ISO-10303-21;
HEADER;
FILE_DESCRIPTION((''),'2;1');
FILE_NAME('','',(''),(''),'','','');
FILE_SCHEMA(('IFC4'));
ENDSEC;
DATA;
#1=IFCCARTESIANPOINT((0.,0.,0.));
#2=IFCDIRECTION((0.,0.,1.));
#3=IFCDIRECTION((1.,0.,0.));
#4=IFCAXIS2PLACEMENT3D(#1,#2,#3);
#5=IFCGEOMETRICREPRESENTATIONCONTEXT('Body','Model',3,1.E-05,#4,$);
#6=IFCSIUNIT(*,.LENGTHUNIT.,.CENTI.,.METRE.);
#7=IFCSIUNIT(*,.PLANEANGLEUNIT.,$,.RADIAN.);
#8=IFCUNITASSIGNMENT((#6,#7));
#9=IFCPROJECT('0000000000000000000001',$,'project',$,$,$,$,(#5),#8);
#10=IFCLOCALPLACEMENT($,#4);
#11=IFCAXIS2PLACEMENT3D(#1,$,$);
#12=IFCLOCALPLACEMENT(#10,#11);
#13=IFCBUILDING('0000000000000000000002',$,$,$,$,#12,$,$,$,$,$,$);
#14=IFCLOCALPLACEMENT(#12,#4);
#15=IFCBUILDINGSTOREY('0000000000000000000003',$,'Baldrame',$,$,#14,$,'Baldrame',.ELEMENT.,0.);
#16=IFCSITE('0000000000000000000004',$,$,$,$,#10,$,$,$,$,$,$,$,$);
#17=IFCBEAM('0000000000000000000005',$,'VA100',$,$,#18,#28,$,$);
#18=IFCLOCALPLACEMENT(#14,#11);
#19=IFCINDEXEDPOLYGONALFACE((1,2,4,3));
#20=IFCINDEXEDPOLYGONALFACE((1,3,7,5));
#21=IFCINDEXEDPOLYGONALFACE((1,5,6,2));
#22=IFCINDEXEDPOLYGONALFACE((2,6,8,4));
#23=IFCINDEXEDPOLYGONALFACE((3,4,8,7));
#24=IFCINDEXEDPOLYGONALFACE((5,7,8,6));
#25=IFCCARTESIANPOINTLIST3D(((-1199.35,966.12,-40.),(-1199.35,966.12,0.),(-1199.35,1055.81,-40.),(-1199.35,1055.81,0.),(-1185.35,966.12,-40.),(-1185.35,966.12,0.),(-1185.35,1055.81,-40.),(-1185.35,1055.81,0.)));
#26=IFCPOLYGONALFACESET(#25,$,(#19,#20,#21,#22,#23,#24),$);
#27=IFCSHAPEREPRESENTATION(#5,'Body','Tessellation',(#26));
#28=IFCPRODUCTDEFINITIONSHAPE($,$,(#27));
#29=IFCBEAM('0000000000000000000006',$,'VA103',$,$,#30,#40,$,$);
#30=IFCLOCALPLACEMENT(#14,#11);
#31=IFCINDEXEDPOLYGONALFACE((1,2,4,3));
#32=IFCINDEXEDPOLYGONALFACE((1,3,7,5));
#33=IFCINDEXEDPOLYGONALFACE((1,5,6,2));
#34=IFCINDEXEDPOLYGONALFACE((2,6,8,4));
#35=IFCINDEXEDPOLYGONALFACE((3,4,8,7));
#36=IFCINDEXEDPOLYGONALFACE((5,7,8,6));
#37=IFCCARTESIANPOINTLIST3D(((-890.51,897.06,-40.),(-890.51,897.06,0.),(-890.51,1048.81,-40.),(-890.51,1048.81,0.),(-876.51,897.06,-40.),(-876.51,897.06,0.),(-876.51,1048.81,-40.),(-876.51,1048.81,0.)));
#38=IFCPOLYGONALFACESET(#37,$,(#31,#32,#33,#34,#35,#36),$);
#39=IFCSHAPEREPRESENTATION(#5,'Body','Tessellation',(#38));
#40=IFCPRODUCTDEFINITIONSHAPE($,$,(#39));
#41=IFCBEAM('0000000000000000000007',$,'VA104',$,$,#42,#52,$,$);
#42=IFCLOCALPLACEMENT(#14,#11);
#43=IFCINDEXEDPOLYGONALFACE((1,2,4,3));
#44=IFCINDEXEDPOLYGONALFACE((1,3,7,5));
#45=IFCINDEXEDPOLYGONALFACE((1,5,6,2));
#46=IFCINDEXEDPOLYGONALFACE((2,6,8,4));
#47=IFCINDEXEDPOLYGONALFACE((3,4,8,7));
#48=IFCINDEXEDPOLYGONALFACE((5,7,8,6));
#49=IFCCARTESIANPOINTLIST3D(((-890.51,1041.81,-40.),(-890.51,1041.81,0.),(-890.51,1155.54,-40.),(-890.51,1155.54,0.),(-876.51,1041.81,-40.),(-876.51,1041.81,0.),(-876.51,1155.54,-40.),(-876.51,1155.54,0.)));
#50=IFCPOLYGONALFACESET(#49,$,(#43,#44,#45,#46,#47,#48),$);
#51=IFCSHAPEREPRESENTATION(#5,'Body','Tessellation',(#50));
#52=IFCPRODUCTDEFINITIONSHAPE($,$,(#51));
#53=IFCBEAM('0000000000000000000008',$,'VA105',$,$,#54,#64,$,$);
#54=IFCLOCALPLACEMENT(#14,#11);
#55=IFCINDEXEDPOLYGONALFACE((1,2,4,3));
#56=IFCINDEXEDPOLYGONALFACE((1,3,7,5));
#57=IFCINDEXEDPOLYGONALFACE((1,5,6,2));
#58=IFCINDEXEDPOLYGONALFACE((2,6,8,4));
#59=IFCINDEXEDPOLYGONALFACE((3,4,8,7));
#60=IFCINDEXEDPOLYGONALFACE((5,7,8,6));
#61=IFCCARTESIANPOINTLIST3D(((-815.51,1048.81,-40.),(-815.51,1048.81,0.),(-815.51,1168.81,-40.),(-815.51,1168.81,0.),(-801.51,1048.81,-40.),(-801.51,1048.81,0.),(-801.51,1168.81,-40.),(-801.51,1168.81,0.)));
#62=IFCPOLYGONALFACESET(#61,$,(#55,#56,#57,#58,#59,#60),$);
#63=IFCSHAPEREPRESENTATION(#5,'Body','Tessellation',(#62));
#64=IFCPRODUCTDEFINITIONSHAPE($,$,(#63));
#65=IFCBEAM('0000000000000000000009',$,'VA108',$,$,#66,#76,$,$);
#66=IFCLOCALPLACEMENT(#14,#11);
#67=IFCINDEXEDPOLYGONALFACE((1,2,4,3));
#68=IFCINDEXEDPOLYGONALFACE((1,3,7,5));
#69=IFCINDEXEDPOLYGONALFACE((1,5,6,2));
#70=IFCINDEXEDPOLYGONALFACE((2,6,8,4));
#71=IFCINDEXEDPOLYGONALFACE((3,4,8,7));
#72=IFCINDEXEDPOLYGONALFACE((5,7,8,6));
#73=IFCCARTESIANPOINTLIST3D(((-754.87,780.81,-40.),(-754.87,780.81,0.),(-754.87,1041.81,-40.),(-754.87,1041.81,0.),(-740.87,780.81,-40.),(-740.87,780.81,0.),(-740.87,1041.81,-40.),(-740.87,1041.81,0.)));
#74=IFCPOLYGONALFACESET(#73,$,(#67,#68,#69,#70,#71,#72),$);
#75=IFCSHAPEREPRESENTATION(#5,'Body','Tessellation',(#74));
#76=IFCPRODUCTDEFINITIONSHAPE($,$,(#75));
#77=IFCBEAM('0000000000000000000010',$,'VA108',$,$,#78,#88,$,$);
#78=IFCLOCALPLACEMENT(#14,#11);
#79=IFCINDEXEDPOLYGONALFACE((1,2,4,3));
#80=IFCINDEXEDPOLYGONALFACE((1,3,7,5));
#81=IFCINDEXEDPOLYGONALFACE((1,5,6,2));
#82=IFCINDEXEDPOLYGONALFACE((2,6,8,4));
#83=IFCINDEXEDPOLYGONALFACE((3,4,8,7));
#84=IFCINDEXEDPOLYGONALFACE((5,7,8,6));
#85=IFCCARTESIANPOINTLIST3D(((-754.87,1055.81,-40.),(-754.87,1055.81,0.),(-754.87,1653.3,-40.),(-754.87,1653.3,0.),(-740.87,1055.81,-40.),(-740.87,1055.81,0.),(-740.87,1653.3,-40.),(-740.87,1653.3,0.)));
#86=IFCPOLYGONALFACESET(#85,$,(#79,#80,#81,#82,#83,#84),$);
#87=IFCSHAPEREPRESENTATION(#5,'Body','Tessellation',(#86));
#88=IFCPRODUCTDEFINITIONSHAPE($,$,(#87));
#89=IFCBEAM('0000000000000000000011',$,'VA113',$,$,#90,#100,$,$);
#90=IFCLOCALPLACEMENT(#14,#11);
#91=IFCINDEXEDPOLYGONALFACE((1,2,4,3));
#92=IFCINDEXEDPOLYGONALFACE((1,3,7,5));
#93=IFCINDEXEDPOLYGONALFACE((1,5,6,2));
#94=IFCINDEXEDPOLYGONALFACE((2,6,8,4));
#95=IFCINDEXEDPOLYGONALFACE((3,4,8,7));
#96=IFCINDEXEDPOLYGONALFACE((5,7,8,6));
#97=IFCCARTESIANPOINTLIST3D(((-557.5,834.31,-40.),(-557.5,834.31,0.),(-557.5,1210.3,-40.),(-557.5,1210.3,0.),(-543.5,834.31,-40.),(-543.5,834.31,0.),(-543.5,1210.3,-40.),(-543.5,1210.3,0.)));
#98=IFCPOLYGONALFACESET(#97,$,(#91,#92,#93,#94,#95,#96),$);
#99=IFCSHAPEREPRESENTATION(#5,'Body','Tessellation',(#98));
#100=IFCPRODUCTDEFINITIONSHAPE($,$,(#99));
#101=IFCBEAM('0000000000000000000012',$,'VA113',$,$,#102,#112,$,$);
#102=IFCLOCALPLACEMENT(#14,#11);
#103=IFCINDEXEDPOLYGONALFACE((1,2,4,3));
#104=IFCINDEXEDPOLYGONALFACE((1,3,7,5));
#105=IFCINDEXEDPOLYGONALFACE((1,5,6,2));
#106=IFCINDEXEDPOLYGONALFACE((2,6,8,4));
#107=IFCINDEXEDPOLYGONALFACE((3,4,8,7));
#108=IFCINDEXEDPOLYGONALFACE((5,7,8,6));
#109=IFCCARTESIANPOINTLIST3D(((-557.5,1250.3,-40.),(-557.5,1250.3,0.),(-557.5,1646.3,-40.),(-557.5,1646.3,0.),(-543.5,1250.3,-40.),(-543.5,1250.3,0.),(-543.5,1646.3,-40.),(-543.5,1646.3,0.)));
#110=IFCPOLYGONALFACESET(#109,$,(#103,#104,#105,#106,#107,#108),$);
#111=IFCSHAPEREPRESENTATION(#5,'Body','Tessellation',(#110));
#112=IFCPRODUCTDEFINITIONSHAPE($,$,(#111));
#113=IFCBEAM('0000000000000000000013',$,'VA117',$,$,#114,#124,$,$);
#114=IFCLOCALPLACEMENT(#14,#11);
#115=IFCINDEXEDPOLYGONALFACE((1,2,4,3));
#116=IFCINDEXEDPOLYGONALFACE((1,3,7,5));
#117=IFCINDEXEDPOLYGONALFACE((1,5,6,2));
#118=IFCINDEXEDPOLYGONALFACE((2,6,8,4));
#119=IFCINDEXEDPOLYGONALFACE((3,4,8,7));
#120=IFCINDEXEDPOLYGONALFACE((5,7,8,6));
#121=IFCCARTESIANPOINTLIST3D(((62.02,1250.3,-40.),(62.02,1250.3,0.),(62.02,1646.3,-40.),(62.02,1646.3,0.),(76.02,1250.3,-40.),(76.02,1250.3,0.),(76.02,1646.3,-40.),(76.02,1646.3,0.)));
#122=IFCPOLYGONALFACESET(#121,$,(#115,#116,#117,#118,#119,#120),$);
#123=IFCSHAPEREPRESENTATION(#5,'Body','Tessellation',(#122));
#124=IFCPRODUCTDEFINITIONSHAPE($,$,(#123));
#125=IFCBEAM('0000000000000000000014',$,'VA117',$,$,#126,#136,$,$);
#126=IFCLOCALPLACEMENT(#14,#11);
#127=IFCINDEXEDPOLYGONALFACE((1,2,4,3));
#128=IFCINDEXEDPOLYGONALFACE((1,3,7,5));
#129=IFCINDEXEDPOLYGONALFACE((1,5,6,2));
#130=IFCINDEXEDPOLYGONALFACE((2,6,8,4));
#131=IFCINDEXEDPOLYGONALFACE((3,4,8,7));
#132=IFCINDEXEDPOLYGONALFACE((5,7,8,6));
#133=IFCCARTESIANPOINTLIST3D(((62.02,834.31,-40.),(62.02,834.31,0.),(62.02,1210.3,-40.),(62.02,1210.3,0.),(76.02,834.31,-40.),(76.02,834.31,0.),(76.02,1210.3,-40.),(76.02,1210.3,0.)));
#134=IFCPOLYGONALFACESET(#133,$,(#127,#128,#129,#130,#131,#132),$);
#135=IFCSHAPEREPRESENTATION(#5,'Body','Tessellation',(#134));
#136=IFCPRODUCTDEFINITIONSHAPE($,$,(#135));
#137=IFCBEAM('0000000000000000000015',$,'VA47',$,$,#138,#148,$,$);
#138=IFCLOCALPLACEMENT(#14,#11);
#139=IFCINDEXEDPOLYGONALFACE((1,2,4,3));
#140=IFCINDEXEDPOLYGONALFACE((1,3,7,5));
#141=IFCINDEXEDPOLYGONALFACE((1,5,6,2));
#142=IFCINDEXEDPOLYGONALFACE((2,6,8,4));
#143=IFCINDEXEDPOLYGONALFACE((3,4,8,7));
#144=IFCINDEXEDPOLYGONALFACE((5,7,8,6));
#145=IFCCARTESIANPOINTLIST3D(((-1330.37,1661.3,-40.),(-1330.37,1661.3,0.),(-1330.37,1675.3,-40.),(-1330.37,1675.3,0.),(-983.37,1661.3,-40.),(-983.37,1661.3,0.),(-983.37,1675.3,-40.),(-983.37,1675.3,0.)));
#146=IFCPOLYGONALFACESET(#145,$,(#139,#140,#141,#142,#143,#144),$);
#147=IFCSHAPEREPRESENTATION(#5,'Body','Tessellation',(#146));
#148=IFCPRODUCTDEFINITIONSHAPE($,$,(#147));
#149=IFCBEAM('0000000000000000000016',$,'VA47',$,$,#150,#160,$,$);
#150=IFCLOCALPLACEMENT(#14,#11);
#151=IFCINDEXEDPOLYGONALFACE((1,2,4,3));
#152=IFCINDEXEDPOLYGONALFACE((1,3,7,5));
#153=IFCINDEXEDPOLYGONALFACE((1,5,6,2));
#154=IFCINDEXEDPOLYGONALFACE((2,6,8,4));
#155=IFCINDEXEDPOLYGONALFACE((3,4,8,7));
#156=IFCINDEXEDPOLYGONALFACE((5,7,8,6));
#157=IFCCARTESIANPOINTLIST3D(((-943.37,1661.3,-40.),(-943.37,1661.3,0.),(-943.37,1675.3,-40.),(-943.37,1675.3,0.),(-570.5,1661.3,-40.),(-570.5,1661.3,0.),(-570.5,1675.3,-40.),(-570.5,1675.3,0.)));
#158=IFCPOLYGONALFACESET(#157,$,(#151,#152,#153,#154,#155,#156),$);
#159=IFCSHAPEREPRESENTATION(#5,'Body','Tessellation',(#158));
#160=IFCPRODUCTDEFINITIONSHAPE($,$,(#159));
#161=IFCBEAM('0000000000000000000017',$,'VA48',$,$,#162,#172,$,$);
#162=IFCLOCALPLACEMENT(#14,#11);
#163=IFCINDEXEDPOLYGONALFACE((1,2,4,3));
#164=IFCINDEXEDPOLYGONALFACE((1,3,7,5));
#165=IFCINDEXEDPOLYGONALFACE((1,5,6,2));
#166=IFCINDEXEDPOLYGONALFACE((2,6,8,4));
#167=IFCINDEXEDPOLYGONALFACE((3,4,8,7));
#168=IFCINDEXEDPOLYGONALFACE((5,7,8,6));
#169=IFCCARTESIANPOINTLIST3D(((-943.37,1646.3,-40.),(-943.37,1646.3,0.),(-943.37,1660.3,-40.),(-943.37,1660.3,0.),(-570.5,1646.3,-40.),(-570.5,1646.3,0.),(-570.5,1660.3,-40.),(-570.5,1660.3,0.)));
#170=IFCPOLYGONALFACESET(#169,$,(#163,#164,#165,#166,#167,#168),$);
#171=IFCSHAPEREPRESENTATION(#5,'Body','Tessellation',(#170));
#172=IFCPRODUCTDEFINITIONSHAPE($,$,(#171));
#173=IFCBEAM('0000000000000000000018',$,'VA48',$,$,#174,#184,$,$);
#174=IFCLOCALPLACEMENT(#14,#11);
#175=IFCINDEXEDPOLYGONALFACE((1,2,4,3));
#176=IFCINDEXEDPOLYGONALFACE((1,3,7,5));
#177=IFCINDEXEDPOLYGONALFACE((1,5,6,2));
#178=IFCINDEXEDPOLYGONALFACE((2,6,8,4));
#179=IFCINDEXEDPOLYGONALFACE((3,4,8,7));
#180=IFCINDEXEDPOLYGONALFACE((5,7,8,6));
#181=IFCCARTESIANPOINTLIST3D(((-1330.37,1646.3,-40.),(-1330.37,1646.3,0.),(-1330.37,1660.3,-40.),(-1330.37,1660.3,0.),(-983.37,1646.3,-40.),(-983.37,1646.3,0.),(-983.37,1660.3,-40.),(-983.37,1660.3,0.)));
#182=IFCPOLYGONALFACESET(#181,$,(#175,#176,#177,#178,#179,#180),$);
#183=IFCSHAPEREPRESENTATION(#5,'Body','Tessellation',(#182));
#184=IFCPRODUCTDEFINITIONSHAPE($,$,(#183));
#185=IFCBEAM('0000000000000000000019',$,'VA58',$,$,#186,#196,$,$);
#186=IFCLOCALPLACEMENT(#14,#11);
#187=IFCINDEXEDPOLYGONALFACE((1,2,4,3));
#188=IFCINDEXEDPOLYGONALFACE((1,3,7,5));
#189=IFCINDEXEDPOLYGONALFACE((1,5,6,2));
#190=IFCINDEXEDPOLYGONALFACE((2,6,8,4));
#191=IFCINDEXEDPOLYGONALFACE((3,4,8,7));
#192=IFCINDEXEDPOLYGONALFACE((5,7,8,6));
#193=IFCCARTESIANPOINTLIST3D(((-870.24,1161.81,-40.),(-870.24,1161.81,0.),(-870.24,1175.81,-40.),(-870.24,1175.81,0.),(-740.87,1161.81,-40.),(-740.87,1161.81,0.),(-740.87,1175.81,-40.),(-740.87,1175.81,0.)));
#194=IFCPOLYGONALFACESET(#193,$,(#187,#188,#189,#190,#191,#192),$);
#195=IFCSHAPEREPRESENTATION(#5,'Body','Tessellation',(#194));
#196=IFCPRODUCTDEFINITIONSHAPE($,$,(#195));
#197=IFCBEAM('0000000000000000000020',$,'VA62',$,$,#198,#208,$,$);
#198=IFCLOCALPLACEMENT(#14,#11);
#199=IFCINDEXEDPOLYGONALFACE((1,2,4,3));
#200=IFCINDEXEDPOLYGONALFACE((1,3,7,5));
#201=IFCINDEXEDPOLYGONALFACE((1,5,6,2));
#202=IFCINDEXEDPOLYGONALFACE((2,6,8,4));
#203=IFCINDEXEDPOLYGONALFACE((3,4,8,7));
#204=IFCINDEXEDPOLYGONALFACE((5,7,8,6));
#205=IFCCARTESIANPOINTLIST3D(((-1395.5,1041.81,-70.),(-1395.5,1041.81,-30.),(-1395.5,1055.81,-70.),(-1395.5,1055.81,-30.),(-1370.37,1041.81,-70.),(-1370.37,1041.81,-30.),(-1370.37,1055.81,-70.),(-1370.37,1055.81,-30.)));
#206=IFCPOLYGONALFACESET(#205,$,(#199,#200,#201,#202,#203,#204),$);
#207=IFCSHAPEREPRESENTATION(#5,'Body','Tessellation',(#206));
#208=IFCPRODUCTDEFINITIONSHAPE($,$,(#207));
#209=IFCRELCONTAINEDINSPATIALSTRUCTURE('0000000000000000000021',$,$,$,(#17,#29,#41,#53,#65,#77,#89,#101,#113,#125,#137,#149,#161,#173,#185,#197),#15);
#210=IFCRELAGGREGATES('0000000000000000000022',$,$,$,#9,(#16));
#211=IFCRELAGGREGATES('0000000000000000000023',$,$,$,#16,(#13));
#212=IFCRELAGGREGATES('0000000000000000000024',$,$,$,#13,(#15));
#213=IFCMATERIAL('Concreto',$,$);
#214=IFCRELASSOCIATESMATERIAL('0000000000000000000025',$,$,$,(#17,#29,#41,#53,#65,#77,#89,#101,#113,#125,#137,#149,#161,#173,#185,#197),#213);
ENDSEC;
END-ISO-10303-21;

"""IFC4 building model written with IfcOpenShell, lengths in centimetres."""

from ifc_helpers import new_model, si_unit, frame, origin, origin_with_axes, origin_2d_with_axis, place, context, project, spatial, rectangle, extrude, material, element, save


model = new_model("IFC4")

# Units and contexts
model_context = context("Model", 3, precision=1e-05, world=origin_with_axes(), identifier="Body")
ifc_project = project(units=[si_unit("LENGTHUNIT", "METRE", prefix="CENTI"), si_unit("PLANEANGLEUNIT", "RADIAN")], contexts=[model_context])

# Site, building, storey
site_placement = place(None, origin_with_axes())
site = spatial("IfcSite", under=ifc_project, at=site_placement)
building_placement = place(site_placement, origin())
building = spatial("IfcBuilding", under=site, at=building_placement)
storey_placement = place(building_placement, origin_with_axes())
storey = spatial("IfcBuildingStorey", under=building, at=storey_placement, Name="Baldrame", LongName="Baldrame", CompositionType="ELEMENT", Elevation=0.0)

# Shared definitions
ifc_material = material(Name="Concreto")

# Beams
beam_1_placement = place(storey_placement, frame((-1192.35, 1010.96, 0.0), z_axis=(0.0, 0.0, 1.0), x_axis=(1.0, 0.0, 0.0)))
element("IfcBeam", 1, at=beam_1_placement, inside=storey, material=ifc_material, Name="VA100", context=model_context, shape_type="SolidModel", body=[
    extrude(rectangle(XDim=14.0, YDim=40.0, at=origin_2d_with_axis()), frame((0.0, -44.85, -20.0), z_axis=(0.0, 1.0, 0.0), x_axis=(-1.0, 0.0, 0.0)), (0.0, 0.0, 1.0), 89.69),
])
beam_2_placement = place(storey_placement, frame((-883.51, 972.93, 0.0), z_axis=(0.0, 0.0, 1.0), x_axis=(1.0, 0.0, 0.0)))
element("IfcBeam", 2, at=beam_2_placement, inside=storey, material=ifc_material, Name="VA103", context=model_context, shape_type="SolidModel", body=[
    extrude(rectangle(XDim=14.0, YDim=40.0, at=origin_2d_with_axis()), frame((0.0, -75.88, -20.0), z_axis=(0.0, 1.0, 0.0), x_axis=(-1.0, 0.0, 0.0)), (0.0, 0.0, 1.0), 151.75),
])
beam_3_placement = place(storey_placement, frame((-883.51, 1098.68, 0.0), z_axis=(0.0, 0.0, 1.0), x_axis=(1.0, 0.0, 0.0)))
element("IfcBeam", 3, at=beam_3_placement, inside=storey, material=ifc_material, Name="VA104", context=model_context, shape_type="SolidModel", body=[
    extrude(rectangle(XDim=14.0, YDim=40.0, at=origin_2d_with_axis()), frame((0.0, -56.87, -20.0), z_axis=(0.0, 1.0, 0.0), x_axis=(-1.0, 0.0, 0.0)), (0.0, 0.0, 1.0), 113.73),
])
beam_4_placement = place(storey_placement, frame((-808.51, 1108.81, 0.0), z_axis=(0.0, 0.0, 1.0), x_axis=(1.0, 0.0, 0.0)))
element("IfcBeam", 4, at=beam_4_placement, inside=storey, material=ifc_material, Name="VA105", context=model_context, shape_type="SolidModel", body=[
    extrude(rectangle(XDim=14.0, YDim=40.0, at=origin_2d_with_axis()), frame((0.0, -60.0, -20.0), z_axis=(0.0, 1.0, 0.0), x_axis=(-1.0, 0.0, 0.0)), (0.0, 0.0, 1.0), 120.0),
])
beam_5_placement = place(storey_placement, frame((-747.87, 911.31, 0.0), z_axis=(0.0, 0.0, 1.0), x_axis=(1.0, 0.0, 0.0)))
element("IfcBeam", 5, at=beam_5_placement, inside=storey, material=ifc_material, Name="VA108", context=model_context, shape_type="SolidModel", body=[
    extrude(rectangle(XDim=14.0, YDim=40.0, at=origin_2d_with_axis()), frame((0.0, -130.5, -20.0), z_axis=(0.0, 1.0, 0.0), x_axis=(-1.0, 0.0, 0.0)), (0.0, 0.0, 1.0), 261.0),
])
beam_6_placement = place(storey_placement, frame((-747.87, 1354.56, 0.0), z_axis=(0.0, 0.0, 1.0), x_axis=(1.0, 0.0, 0.0)))
element("IfcBeam", 6, at=beam_6_placement, inside=storey, material=ifc_material, Name="VA108", context=model_context, shape_type="SolidModel", body=[
    extrude(rectangle(XDim=14.0, YDim=40.0, at=origin_2d_with_axis()), frame((0.0, -298.75, -20.0), z_axis=(0.0, 1.0, 0.0), x_axis=(-1.0, 0.0, 0.0)), (0.0, 0.0, 1.0), 597.49),
])
beam_7_placement = place(storey_placement, frame((-550.5, 1022.3, 0.0), z_axis=(0.0, 0.0, 1.0), x_axis=(1.0, 0.0, 0.0)))
element("IfcBeam", 7, at=beam_7_placement, inside=storey, material=ifc_material, Name="VA113", context=model_context, shape_type="SolidModel", body=[
    extrude(rectangle(XDim=14.0, YDim=40.0, at=origin_2d_with_axis()), frame((0.0, -188.0, -20.0), z_axis=(0.0, 1.0, 0.0), x_axis=(-1.0, 0.0, 0.0)), (0.0, 0.0, 1.0), 375.99),
])
for number, where, z_axis, x_axis, name in (
    (8, (-550.5, 1448.3, 0.0), (0.0, 0.0, 1.0), (1.0, 0.0, 0.0), "VA113"),
    (9, (69.02, 1448.3, 0.0), (0.0, 0.0, 1.0), (1.0, 0.0, 0.0), "VA117"),
):
    element("IfcBeam", number, at=place(storey_placement, frame(where, z_axis=z_axis, x_axis=x_axis)), inside=storey, material=ifc_material, Name=name, context=model_context, shape_type="SolidModel", body=[
        extrude(rectangle(XDim=14.0, YDim=40.0, at=origin_2d_with_axis()), frame((0.0, -198.0, -20.0), z_axis=(0.0, 1.0, 0.0), x_axis=(-1.0, 0.0, 0.0)), (0.0, 0.0, 1.0), 396.0),
    ])
beam_8_placement = place(storey_placement, frame((69.02, 1022.3, 0.0), z_axis=(0.0, 0.0, 1.0), x_axis=(1.0, 0.0, 0.0)))
element("IfcBeam", 10, at=beam_8_placement, inside=storey, material=ifc_material, Name="VA117", context=model_context, shape_type="SolidModel", body=[
    extrude(rectangle(XDim=14.0, YDim=40.0, at=origin_2d_with_axis()), frame((0.0, -188.0, -20.0), z_axis=(0.0, 1.0, 0.0), x_axis=(-1.0, 0.0, 0.0)), (0.0, 0.0, 1.0), 375.99),
])
beam_9_placement = place(storey_placement, frame((-1156.87, 1668.3, 0.0), z_axis=(0.0, 0.0, 1.0), x_axis=(1.0, 0.0, 0.0)))
element("IfcBeam", 11, at=beam_9_placement, inside=storey, material=ifc_material, Name="VA47", context=model_context, shape_type="SolidModel", body=[
    extrude(rectangle(XDim=14.0, YDim=40.0, at=origin_2d_with_axis()), frame((-173.5, 0.0, -20.0), z_axis=(1.0, 0.0, 0.0), x_axis=(0.0, 1.0, 0.0)), (0.0, 0.0, 1.0), 347.0),
])
for number, where, z_axis, x_axis, name in (
    (12, (-756.93, 1668.3, 0.0), (0.0, 0.0, 1.0), (1.0, 0.0, 0.0), "VA47"),
    (13, (-756.93, 1653.3, 0.0), (0.0, 0.0, 1.0), (1.0, 0.0, 0.0), "VA48"),
):
    element("IfcBeam", number, at=place(storey_placement, frame(where, z_axis=z_axis, x_axis=x_axis)), inside=storey, material=ifc_material, Name=name, context=model_context, shape_type="SolidModel", body=[
        extrude(rectangle(XDim=14.0, YDim=40.0, at=origin_2d_with_axis()), frame((-186.44, 0.0, -20.0), z_axis=(1.0, 0.0, 0.0), x_axis=(0.0, 1.0, 0.0)), (0.0, 0.0, 1.0), 372.87),
    ])
beam_10_placement = place(storey_placement, frame((-1156.87, 1653.3, 0.0), z_axis=(0.0, 0.0, 1.0), x_axis=(1.0, 0.0, 0.0)))
element("IfcBeam", 14, at=beam_10_placement, inside=storey, material=ifc_material, Name="VA48", context=model_context, shape_type="SolidModel", body=[
    extrude(rectangle(XDim=14.0, YDim=40.0, at=origin_2d_with_axis()), frame((-173.5, 0.0, -20.0), z_axis=(1.0, 0.0, 0.0), x_axis=(0.0, 1.0, 0.0)), (0.0, 0.0, 1.0), 347.0),
])
beam_11_placement = place(storey_placement, frame((-805.56, 1168.81, 0.0), z_axis=(0.0, 0.0, 1.0), x_axis=(1.0, 0.0, 0.0)))
element("IfcBeam", 15, at=beam_11_placement, inside=storey, material=ifc_material, Name="VA58", context=model_context, shape_type="SolidModel", body=[
    extrude(rectangle(XDim=14.0, YDim=40.0, at=origin_2d_with_axis()), frame((-64.69, 0.0, -20.0), z_axis=(1.0, 0.0, 0.0), x_axis=(0.0, 1.0, 0.0)), (0.0, 0.0, 1.0), 129.37),
])
beam_12_placement = place(storey_placement, frame((-1382.93, 1048.81, -30.0), z_axis=(0.0, 0.0, 1.0), x_axis=(1.0, 0.0, 0.0)))
element("IfcBeam", 16, at=beam_12_placement, inside=storey, material=ifc_material, Name="VA62", context=model_context, shape_type="SolidModel", body=[
    extrude(rectangle(XDim=14.0, YDim=40.0, at=origin_2d_with_axis()), frame((-12.56, 0.0, -20.0), z_axis=(1.0, 0.0, 0.0), x_axis=(0.0, 1.0, 0.0)), (0.0, 0.0, 1.0), 25.13),
])

save(model, "model.ifc")
